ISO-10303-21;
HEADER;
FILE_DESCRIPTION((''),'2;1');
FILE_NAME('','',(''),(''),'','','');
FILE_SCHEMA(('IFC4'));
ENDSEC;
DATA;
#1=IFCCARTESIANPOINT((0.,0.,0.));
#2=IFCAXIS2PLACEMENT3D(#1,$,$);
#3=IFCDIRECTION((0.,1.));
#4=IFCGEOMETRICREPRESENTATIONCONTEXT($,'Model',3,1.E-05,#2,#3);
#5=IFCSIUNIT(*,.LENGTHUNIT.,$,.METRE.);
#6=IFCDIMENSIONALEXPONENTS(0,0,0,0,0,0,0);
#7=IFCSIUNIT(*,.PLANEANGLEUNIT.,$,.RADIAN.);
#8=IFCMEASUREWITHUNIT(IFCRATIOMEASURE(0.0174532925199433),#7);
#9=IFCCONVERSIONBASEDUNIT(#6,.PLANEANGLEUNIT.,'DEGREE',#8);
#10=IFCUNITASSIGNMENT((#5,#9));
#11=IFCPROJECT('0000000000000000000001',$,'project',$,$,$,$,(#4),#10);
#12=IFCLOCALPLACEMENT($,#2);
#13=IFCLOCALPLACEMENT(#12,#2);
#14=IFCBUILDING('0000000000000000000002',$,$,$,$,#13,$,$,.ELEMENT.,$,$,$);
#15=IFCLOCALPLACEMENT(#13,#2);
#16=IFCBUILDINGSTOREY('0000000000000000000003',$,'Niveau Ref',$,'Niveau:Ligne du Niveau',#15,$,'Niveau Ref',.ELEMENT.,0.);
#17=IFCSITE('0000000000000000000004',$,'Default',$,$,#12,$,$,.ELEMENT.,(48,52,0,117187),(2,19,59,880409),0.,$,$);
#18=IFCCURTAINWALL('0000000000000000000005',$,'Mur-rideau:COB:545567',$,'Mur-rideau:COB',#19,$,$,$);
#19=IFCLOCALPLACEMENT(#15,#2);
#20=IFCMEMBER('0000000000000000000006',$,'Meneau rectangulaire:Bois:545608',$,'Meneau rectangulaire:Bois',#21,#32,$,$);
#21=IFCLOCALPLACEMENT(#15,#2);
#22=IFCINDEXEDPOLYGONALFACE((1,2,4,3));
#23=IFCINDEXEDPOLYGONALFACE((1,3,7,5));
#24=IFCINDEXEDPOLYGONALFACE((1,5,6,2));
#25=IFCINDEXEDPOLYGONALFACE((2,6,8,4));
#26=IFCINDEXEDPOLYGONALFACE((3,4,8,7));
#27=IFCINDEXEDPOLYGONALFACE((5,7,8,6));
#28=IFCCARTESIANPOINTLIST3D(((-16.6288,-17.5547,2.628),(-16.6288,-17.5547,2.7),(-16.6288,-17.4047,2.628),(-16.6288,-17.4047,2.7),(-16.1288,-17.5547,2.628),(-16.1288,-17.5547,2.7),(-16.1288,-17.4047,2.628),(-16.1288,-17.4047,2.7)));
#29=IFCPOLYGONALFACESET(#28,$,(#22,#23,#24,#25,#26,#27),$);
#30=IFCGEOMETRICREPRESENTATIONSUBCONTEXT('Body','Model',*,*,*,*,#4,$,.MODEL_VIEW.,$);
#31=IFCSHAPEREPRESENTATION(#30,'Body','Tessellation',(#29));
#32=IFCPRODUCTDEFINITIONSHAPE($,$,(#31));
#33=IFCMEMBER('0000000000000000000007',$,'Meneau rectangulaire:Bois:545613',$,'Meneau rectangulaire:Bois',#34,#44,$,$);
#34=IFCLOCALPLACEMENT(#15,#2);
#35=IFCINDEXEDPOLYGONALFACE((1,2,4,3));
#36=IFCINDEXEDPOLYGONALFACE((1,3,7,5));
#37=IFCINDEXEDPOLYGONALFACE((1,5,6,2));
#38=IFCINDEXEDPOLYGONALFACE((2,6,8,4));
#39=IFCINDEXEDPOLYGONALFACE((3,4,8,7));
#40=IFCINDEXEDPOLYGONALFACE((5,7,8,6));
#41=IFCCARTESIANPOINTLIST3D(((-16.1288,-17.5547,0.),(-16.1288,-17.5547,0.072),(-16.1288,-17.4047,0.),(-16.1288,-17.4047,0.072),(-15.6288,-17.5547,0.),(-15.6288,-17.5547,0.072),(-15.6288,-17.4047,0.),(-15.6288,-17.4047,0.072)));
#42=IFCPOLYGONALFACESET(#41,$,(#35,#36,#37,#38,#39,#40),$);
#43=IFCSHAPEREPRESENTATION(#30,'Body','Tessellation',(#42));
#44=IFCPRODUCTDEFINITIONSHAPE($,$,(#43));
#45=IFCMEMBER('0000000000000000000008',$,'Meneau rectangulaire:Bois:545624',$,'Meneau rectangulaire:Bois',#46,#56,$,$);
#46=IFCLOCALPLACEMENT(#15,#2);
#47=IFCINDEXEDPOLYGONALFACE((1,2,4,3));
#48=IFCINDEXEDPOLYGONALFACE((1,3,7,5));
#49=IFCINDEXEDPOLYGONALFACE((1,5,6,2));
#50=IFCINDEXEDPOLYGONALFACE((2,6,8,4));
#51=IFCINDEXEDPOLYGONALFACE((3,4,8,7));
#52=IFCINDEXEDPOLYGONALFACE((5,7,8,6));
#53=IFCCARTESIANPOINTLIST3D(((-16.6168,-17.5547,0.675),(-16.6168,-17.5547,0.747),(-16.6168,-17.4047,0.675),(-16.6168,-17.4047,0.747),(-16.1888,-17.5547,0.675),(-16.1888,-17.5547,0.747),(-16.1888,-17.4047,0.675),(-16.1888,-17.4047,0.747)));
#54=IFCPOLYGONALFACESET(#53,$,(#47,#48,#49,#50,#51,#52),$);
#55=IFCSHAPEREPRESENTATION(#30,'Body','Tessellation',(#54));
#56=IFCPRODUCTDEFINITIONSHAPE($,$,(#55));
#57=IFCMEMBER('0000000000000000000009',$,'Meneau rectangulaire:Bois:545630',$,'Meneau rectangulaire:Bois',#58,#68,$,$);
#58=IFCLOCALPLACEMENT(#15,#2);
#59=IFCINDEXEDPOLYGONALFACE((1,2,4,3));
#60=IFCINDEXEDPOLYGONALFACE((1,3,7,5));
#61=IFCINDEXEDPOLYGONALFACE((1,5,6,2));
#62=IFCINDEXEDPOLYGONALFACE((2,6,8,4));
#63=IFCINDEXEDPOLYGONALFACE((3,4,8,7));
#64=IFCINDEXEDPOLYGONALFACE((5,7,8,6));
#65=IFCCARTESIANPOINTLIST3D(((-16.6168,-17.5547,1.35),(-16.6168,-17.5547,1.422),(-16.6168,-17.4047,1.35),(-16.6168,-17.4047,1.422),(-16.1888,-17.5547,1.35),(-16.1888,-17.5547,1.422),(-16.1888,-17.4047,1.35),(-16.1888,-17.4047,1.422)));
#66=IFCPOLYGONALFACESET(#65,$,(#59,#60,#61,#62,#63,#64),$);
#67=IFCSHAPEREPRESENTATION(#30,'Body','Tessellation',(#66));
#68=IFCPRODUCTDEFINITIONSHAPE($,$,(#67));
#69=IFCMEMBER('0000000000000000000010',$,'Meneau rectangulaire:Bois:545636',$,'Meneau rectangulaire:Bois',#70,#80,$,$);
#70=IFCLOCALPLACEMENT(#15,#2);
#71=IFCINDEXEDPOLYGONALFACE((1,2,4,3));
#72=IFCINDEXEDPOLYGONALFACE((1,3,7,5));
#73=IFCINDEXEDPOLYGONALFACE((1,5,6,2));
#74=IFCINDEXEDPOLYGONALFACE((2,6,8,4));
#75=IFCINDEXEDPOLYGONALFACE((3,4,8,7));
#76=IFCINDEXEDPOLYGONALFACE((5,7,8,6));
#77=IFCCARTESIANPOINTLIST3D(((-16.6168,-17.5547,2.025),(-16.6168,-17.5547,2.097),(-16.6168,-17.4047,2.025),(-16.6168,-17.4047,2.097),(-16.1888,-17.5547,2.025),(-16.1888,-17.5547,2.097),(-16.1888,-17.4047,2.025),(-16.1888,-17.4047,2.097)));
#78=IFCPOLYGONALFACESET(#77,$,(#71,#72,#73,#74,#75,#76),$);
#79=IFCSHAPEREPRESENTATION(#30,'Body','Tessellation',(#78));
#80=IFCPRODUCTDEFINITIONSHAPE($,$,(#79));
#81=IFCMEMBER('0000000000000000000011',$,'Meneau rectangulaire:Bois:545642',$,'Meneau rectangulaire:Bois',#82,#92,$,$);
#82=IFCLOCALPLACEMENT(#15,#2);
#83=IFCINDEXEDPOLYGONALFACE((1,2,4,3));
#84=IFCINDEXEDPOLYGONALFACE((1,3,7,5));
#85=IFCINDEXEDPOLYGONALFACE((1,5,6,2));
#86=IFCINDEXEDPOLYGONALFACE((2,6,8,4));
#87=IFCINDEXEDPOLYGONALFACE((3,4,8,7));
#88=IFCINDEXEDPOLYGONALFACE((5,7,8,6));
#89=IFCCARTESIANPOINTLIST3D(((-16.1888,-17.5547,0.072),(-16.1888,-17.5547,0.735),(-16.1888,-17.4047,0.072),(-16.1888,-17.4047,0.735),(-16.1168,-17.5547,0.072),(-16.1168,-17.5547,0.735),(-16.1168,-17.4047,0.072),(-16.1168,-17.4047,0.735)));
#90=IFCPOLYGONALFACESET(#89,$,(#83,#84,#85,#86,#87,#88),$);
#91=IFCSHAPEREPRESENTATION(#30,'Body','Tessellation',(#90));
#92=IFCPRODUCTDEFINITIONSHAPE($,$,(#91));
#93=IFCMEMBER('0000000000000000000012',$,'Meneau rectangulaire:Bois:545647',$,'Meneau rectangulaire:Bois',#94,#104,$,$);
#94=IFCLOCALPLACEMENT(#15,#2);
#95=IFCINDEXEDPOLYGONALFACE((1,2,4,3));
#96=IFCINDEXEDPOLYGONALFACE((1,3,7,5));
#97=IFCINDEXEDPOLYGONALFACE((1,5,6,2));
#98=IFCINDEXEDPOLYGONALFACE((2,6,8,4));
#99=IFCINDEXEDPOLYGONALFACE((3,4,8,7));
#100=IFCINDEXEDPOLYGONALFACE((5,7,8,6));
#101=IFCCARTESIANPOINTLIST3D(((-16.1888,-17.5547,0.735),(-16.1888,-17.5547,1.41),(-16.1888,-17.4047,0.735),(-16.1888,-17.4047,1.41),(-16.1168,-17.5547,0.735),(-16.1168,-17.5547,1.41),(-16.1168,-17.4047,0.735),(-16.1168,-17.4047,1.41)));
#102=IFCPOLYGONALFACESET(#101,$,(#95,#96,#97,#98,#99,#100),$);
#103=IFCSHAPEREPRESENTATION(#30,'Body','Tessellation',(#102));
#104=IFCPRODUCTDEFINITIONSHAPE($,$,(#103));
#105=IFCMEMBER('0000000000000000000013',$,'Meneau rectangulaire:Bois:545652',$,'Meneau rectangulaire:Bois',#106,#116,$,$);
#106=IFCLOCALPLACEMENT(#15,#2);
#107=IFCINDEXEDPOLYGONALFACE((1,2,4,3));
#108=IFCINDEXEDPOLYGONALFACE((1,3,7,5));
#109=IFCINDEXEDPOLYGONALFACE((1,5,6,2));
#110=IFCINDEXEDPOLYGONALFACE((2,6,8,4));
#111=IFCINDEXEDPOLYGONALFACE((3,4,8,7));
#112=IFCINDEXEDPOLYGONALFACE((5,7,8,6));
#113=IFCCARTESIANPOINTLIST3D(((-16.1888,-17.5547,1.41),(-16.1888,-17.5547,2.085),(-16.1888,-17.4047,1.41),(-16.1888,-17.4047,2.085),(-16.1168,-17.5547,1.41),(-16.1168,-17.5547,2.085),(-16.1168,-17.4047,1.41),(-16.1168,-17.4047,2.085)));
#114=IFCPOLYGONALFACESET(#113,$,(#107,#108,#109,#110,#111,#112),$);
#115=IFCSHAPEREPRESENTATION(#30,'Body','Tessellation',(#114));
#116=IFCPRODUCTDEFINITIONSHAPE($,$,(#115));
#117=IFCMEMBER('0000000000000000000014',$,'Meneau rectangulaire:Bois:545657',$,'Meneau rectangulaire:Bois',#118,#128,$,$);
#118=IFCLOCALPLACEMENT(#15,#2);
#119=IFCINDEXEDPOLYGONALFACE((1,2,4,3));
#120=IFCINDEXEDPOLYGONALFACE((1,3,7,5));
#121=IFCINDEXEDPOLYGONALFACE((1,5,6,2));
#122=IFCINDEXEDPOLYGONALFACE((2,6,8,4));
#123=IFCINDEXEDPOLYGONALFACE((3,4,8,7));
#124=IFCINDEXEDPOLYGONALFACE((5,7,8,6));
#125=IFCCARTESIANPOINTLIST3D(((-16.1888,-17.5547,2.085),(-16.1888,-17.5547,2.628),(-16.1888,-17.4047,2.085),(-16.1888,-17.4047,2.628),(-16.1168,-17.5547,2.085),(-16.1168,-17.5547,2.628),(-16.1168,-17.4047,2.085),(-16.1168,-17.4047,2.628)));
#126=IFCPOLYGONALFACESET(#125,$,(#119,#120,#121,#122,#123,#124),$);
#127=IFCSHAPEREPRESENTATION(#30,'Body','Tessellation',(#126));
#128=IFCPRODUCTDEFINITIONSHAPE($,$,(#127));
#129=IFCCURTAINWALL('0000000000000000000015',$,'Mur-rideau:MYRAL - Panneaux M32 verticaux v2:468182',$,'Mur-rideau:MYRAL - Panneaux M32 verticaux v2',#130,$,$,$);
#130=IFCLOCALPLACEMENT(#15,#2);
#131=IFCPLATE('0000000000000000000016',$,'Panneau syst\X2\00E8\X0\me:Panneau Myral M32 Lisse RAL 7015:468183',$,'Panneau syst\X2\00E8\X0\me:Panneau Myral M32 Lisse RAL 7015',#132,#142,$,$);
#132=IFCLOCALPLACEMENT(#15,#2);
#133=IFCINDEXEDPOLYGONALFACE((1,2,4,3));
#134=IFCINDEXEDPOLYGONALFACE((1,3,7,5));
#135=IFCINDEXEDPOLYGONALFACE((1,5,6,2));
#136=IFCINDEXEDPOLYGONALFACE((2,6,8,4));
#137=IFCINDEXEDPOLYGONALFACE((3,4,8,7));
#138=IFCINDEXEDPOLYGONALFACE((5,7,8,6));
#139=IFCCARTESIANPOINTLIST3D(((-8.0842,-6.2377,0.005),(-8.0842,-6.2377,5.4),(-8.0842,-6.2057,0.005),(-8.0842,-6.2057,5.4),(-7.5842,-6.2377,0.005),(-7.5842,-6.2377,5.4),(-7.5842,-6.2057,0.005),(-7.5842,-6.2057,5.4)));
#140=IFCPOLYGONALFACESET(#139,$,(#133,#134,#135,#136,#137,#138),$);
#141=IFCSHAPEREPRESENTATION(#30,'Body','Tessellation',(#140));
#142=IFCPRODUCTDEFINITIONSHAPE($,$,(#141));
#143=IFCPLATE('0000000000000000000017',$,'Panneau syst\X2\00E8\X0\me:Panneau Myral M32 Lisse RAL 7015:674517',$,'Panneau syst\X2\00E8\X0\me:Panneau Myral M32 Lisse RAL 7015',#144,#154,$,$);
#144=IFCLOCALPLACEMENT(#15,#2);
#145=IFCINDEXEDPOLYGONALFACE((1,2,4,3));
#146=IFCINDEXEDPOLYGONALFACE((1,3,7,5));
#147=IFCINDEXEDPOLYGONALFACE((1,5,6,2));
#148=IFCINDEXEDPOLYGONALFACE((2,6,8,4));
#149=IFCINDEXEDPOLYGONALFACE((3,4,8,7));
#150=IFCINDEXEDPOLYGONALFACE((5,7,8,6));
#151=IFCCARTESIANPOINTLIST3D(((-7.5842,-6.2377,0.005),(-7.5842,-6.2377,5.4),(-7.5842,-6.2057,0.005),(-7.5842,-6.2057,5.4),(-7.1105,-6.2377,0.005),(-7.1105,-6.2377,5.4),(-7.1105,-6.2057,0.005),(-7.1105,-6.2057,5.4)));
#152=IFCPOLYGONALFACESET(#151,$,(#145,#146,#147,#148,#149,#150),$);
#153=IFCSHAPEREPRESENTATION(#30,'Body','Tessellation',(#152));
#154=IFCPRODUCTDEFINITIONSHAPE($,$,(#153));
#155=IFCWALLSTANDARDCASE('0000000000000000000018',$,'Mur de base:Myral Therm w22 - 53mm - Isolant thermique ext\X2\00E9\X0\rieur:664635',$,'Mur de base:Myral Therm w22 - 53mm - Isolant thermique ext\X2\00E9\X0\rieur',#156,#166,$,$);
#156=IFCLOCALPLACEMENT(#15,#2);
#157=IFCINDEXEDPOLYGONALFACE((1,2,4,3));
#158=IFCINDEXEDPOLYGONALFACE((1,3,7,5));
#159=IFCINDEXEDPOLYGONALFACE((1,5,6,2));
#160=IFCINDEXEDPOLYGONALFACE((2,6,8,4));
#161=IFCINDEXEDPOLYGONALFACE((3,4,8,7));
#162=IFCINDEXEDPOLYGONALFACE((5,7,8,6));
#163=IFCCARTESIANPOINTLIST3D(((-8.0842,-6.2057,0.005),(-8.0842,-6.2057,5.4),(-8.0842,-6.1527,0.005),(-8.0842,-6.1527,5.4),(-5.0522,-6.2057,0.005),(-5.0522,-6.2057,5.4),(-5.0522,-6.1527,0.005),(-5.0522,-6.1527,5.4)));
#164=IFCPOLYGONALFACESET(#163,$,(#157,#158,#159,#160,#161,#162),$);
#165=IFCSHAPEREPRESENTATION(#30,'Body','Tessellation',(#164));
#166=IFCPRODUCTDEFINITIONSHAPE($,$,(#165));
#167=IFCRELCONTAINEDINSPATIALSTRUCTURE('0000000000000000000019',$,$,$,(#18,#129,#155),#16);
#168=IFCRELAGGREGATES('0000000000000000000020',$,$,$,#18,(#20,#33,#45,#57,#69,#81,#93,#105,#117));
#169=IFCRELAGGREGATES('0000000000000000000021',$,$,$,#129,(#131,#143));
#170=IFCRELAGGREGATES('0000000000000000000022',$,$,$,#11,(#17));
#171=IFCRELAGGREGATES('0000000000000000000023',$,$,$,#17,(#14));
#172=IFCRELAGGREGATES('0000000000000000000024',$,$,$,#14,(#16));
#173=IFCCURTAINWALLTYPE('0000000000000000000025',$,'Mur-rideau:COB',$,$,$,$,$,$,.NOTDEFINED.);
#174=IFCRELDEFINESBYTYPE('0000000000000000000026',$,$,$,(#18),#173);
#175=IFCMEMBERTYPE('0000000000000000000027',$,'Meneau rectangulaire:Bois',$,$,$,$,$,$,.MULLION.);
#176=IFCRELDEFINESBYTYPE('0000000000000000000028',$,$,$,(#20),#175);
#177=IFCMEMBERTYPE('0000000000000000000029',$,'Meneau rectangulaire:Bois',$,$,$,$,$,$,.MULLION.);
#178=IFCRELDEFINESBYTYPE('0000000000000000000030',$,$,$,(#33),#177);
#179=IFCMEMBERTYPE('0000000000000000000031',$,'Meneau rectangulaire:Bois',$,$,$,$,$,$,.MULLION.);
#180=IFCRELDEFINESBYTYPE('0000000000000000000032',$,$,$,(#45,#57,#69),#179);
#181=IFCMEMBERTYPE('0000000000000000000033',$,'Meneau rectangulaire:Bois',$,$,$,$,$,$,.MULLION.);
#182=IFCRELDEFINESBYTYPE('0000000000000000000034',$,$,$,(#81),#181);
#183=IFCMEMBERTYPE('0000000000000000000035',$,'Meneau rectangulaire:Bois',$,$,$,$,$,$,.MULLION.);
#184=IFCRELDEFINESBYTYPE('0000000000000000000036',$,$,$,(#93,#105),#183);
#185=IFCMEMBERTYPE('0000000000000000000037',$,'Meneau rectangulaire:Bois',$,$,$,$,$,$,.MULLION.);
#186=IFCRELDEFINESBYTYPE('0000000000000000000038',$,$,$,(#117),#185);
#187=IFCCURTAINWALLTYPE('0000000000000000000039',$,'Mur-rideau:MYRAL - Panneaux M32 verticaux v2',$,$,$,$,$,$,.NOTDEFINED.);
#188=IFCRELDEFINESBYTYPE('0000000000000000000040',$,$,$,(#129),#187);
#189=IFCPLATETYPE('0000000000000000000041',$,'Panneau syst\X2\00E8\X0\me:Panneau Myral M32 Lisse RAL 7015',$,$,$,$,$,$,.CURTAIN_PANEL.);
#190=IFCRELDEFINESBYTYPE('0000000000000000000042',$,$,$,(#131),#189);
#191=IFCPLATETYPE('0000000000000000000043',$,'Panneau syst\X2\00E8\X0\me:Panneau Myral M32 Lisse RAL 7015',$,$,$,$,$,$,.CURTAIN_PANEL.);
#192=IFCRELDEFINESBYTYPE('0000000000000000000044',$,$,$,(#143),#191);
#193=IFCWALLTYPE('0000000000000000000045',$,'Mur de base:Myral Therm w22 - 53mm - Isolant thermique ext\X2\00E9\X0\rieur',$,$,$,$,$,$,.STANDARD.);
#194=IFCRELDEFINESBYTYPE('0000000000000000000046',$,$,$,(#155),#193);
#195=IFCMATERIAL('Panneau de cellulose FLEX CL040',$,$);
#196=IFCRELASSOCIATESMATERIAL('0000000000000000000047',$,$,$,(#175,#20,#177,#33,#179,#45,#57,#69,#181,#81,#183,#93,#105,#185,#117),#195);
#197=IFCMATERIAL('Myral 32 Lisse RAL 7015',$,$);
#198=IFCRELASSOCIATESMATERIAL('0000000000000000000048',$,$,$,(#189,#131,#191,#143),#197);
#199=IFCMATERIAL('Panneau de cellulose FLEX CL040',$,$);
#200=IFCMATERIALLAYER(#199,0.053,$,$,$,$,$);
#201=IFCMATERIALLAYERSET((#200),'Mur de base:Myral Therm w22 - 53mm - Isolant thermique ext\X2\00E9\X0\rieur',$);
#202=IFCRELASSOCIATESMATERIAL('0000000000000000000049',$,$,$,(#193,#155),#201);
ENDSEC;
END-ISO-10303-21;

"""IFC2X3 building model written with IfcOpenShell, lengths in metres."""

from ifc_helpers import new_model, entity, si_unit, converted_unit, direction, frame, frame_2d, origin, origin_2d_with_axis, place, context, subcontext, project, spatial, rectangle, extrude, source, transform, mapped, material, layer, layer_set, layer_usage, type_object, type_shapes, element, aggregate, save


model = new_model("IFC2X3")

# Units and contexts
model_context = context("Model", 3, precision=1e-05, world=origin(), true_north=direction((0.0, 1.0)))
body_context = subcontext(model_context, "Body", "Model", "MODEL_VIEW")
ifc_project = project(units=[si_unit("LENGTHUNIT", "METRE"), converted_unit("PLANEANGLEUNIT", "DEGREE", entity("IfcRatioMeasure", 0.0174532925199433), si_unit("PLANEANGLEUNIT", "RADIAN"), dimensions=[0, 0, 0, 0, 0, 0, 0])], contexts=[model_context])

# Site, building, storey
site_placement = place(None, origin())
site = spatial("IfcSite", under=ifc_project, at=site_placement, Name="Default", CompositionType="ELEMENT", RefLatitude=(48, 52, 0, 117187), RefLongitude=(2, 19, 59, 880409), RefElevation=0.0)
building_placement = place(site_placement, origin())
building = spatial("IfcBuilding", under=site, at=building_placement, CompositionType="ELEMENT")
storey_placement = place(building_placement, origin())
storey = spatial("IfcBuildingStorey", under=building, at=storey_placement, Name="Niveau Ref", ObjectType="Niveau:Ligne du Niveau", LongName="Niveau Ref", CompositionType="ELEMENT", Elevation=0.0)

# Curtain wall, members
curtain_wall_type_1 = type_object("IfcCurtainWallType", Name="Mur-rideau:COB", PredefinedType="NOTDEFINED")
curtain_wall_1_placement = place(storey_placement, origin())
curtain_wall_1 = element("IfcCurtainWall", 1, at=curtain_wall_1_placement, inside=storey, type_object=curtain_wall_type_1, Name="Mur-rideau:COB:545567", ObjectType="Mur-rideau:COB")
ifc_material_1 = material(Name="Panneau de cellulose FLEX CL040")
member_type_1 = type_object("IfcMemberType", Name="Meneau rectangulaire:Bois", PredefinedType="MULLION", material=ifc_material_1)
shared_shape_1 = source(origin(), body_context, "Body", "SweptSolid", [
    extrude(rectangle(XDim=0.15, YDim=0.072, at=origin_2d_with_axis()), frame((-0.036, 0.0, -0.5), z_axis=(0.0, 0.0, 1.0), x_axis=(0.0, -1.0, 0.0)), (0.0, 0.0, 1.0), 0.5),
])
type_shapes(member_type_1, [shared_shape_1])
member_1_placement = place(storey_placement, frame((-16.1288, -17.4797, 2.7), z_axis=(1.0, 0.0, 0.0), x_axis=(0.0, 0.0, 1.0)))
member_1 = element("IfcMember", 2, at=member_1_placement, type_object=member_type_1, material=ifc_material_1, Name="Meneau rectangulaire:Bois:545608", ObjectType="Meneau rectangulaire:Bois", context=body_context, shape_type="MappedRepresentation", body=[
    mapped(shared_shape_1, transform((0.0, 0.0, 0.0), scale=1.0)),
])
member_type_2 = type_object("IfcMemberType", Name="Meneau rectangulaire:Bois", PredefinedType="MULLION", material=ifc_material_1)
shared_shape_2 = source(origin(), body_context, "Body", "SweptSolid", [
    extrude(rectangle(XDim=0.15, YDim=0.072, at=origin_2d_with_axis()), frame((-0.036, 0.0, -0.5), z_axis=(0.0, 0.0, 1.0), x_axis=(0.0, -1.0, 0.0)), (0.0, 0.0, 1.0), 0.5),
])
type_shapes(member_type_2, [shared_shape_2])
member_2_placement = place(storey_placement, frame((-16.1288, -17.4797, 0.0), z_axis=(-1.0, 0.0, 0.0), x_axis=(0.0, 0.0, -1.0)))
member_2 = element("IfcMember", 3, at=member_2_placement, type_object=member_type_2, material=ifc_material_1, Name="Meneau rectangulaire:Bois:545613", ObjectType="Meneau rectangulaire:Bois", context=body_context, shape_type="MappedRepresentation", body=[
    mapped(shared_shape_2, transform((0.0, 0.0, 0.0), scale=1.0)),
])
member_type_3 = type_object("IfcMemberType", Name="Meneau rectangulaire:Bois", PredefinedType="MULLION", material=ifc_material_1)
shared_shape_3 = source(origin(), body_context, "Body", "SweptSolid", [
    extrude(rectangle(XDim=0.15, YDim=0.072, at=origin_2d_with_axis()), frame((-0.024, 0.0, -0.428), z_axis=(0.0, 0.0, 1.0), x_axis=(0.0, -1.0, 0.0)), (0.0, 0.0, 1.0), 0.428),
])
type_shapes(member_type_3, [shared_shape_3])
member_3_placement = place(storey_placement, frame((-16.1888, -17.4797, 0.735), z_axis=(1.0, 0.0, 0.0), x_axis=(0.0, 0.0, 1.0)))
member_3 = element("IfcMember", 4, at=member_3_placement, type_object=member_type_3, material=ifc_material_1, Name="Meneau rectangulaire:Bois:545624", ObjectType="Meneau rectangulaire:Bois", context=body_context, shape_type="MappedRepresentation", body=[
    mapped(shared_shape_3, transform((0.0, 0.0, 0.0), scale=1.0)),
])
member_4_placement = place(storey_placement, frame((-16.1888, -17.4797, 1.41), z_axis=(1.0, 0.0, 0.0), x_axis=(0.0, 0.0, 1.0)))
member_4 = element("IfcMember", 5, at=member_4_placement, type_object=member_type_3, material=ifc_material_1, Name="Meneau rectangulaire:Bois:545630", ObjectType="Meneau rectangulaire:Bois", context=body_context, shape_type="MappedRepresentation", body=[
    mapped(shared_shape_3, transform((0.0, 0.0, 0.0), scale=1.0)),
])
member_5_placement = place(storey_placement, frame((-16.1888, -17.4797, 2.085), z_axis=(1.0, 0.0, 0.0), x_axis=(0.0, 0.0, 1.0)))
member_5 = element("IfcMember", 6, at=member_5_placement, type_object=member_type_3, material=ifc_material_1, Name="Meneau rectangulaire:Bois:545636", ObjectType="Meneau rectangulaire:Bois", context=body_context, shape_type="MappedRepresentation", body=[
    mapped(shared_shape_3, transform((0.0, 0.0, 0.0), scale=1.0)),
])
member_type_4 = type_object("IfcMemberType", Name="Meneau rectangulaire:Bois", PredefinedType="MULLION", material=ifc_material_1)
shared_shape_4 = source(origin(), body_context, "Body", "SweptSolid", [
    extrude(rectangle(XDim=0.15, YDim=0.072, at=origin_2d_with_axis()), frame((-0.024, 0.0, -0.663), z_axis=(0.0, 0.0, 1.0), x_axis=(0.0, -1.0, 0.0)), (0.0, 0.0, 1.0), 0.663),
])
type_shapes(member_type_4, [shared_shape_4])
member_6_placement = place(storey_placement, frame((-16.1288, -17.4797, 0.072), z_axis=(0.0, 0.0, -1.0), x_axis=(1.0, 0.0, 0.0)))
member_6 = element("IfcMember", 7, at=member_6_placement, type_object=member_type_4, material=ifc_material_1, Name="Meneau rectangulaire:Bois:545642", ObjectType="Meneau rectangulaire:Bois", context=body_context, shape_type="MappedRepresentation", body=[
    mapped(shared_shape_4, transform((0.0, 0.0, 0.0), scale=1.0)),
])
member_type_5 = type_object("IfcMemberType", Name="Meneau rectangulaire:Bois", PredefinedType="MULLION", material=ifc_material_1)
shared_shape_5 = source(origin(), body_context, "Body", "SweptSolid", [
    extrude(rectangle(XDim=0.15, YDim=0.072, at=origin_2d_with_axis()), frame((-0.024, 0.0, -0.675), z_axis=(0.0, 0.0, 1.0), x_axis=(0.0, -1.0, 0.0)), (0.0, 0.0, 1.0), 0.675),
])
type_shapes(member_type_5, [shared_shape_5])
member_7_placement = place(storey_placement, frame((-16.1288, -17.4797, 0.735), z_axis=(0.0, 0.0, -1.0), x_axis=(1.0, 0.0, 0.0)))
member_7 = element("IfcMember", 8, at=member_7_placement, type_object=member_type_5, material=ifc_material_1, Name="Meneau rectangulaire:Bois:545647", ObjectType="Meneau rectangulaire:Bois", context=body_context, shape_type="MappedRepresentation", body=[
    mapped(shared_shape_5, transform((0.0, 0.0, 0.0), scale=1.0)),
])
member_8_placement = place(storey_placement, frame((-16.1288, -17.4797, 1.41), z_axis=(0.0, 0.0, -1.0), x_axis=(1.0, 0.0, 0.0)))
member_8 = element("IfcMember", 9, at=member_8_placement, type_object=member_type_5, material=ifc_material_1, Name="Meneau rectangulaire:Bois:545652", ObjectType="Meneau rectangulaire:Bois", context=body_context, shape_type="MappedRepresentation", body=[
    mapped(shared_shape_5, transform((0.0, 0.0, 0.0), scale=1.0)),
])
member_type_6 = type_object("IfcMemberType", Name="Meneau rectangulaire:Bois", PredefinedType="MULLION", material=ifc_material_1)
shared_shape_6 = source(origin(), body_context, "Body", "SweptSolid", [
    extrude(rectangle(XDim=0.15, YDim=0.072, at=origin_2d_with_axis()), frame((-0.024, 0.0, -0.543), z_axis=(0.0, 0.0, 1.0), x_axis=(0.0, -1.0, 0.0)), (0.0, 0.0, 1.0), 0.543),
])
type_shapes(member_type_6, [shared_shape_6])
member_9_placement = place(storey_placement, frame((-16.1288, -17.4797, 2.085), z_axis=(0.0, 0.0, -1.0), x_axis=(1.0, 0.0, 0.0)))
member_9 = element("IfcMember", 10, at=member_9_placement, type_object=member_type_6, material=ifc_material_1, Name="Meneau rectangulaire:Bois:545657", ObjectType="Meneau rectangulaire:Bois", context=body_context, shape_type="MappedRepresentation", body=[
    mapped(shared_shape_6, transform((0.0, 0.0, 0.0), scale=1.0)),
])
aggregate(curtain_wall_1, [member_1, member_2, member_3, member_4, member_5, member_6, member_7, member_8, member_9])

# Curtain wall, plates
curtain_wall_type_2 = type_object("IfcCurtainWallType", Name="Mur-rideau:MYRAL - Panneaux M32 verticaux v2", PredefinedType="NOTDEFINED")
curtain_wall_2_placement = place(storey_placement, origin())
curtain_wall_2 = element("IfcCurtainWall", 11, at=curtain_wall_2_placement, inside=storey, type_object=curtain_wall_type_2, Name="Mur-rideau:MYRAL - Panneaux M32 verticaux v2:468182", ObjectType="Mur-rideau:MYRAL - Panneaux M32 verticaux v2")
ifc_material_2 = material(Name="Myral 32 Lisse RAL 7015")
plate_type_1 = type_object("IfcPlateType", Name="Panneau système:Panneau Myral M32 Lisse RAL 7015", PredefinedType="CURTAIN_PANEL", material=ifc_material_2)
shared_shape_7 = source(origin(), body_context, "Body", "SweptSolid", [
    extrude(rectangle(XDim=0.032, YDim=0.5, at=origin_2d_with_axis()), frame((0.0, -0.016, 0.0), z_axis=(0.0, 0.0, 1.0), x_axis=(0.0, 1.0, 0.0)), (0.0, 0.0, 1.0), 5.395),
])
type_shapes(plate_type_1, [shared_shape_7])
plate_1_placement = place(curtain_wall_2_placement, frame((-7.8342, -6.2057, 0.005)))
plate_1 = element("IfcPlate", 12, at=plate_1_placement, type_object=plate_type_1, material=ifc_material_2, Name="Panneau système:Panneau Myral M32 Lisse RAL 7015:468183", ObjectType="Panneau système:Panneau Myral M32 Lisse RAL 7015", context=body_context, shape_type="MappedRepresentation", body=[
    mapped(shared_shape_7, transform((0.0, 0.0, 0.0), scale=1.0)),
])
plate_type_2 = type_object("IfcPlateType", Name="Panneau système:Panneau Myral M32 Lisse RAL 7015", PredefinedType="CURTAIN_PANEL", material=ifc_material_2)
shared_shape_8 = source(origin(), body_context, "Body", "SweptSolid", [
    extrude(rectangle(XDim=0.032, YDim=0.4737, at=origin_2d_with_axis()), frame((0.0, -0.016, 0.0), z_axis=(0.0, 0.0, 1.0), x_axis=(0.0, 1.0, 0.0)), (0.0, 0.0, 1.0), 5.395),
])
type_shapes(plate_type_2, [shared_shape_8])
plate_2_placement = place(curtain_wall_2_placement, frame((-7.3474, -6.2057, 0.005)))
plate_2 = element("IfcPlate", 13, at=plate_2_placement, type_object=plate_type_2, material=ifc_material_2, Name="Panneau système:Panneau Myral M32 Lisse RAL 7015:674517", ObjectType="Panneau système:Panneau Myral M32 Lisse RAL 7015", context=body_context, shape_type="MappedRepresentation", body=[
    mapped(shared_shape_8, transform((0.0, 0.0, 0.0), scale=1.0)),
])
aggregate(curtain_wall_2, [plate_1, plate_2])

# Wall
ifc_material_3 = material(Name="Panneau de cellulose FLEX CL040")
ifc_layer = layer(ifc_material_3, 0.053)
ifc_layer_set = layer_set([ifc_layer], Name="Mur de base:Myral Therm w22 - 53mm - Isolant thermique extérieur")
ifc_layer_usage = layer_usage(ifc_layer_set, "AXIS2", "NEGATIVE", 0.0265)
wall_type = type_object("IfcWallType", Name="Mur de base:Myral Therm w22 - 53mm - Isolant thermique extérieur", PredefinedType="STANDARD", material=ifc_layer_set)
wall_placement = place(storey_placement, frame((-8.0842, -6.1792, 0.005)))
element("IfcWallStandardCase", 14, at=wall_placement, inside=storey, type_object=wall_type, material=ifc_layer_usage, Name="Mur de base:Myral Therm w22 - 53mm - Isolant thermique extérieur:664635", ObjectType="Mur de base:Myral Therm w22 - 53mm - Isolant thermique extérieur", context=body_context, shape_type="SweptSolid", body=[
    extrude(rectangle(XDim=3.032, YDim=0.053, at=frame_2d((1.516, 0.0), x_axis=(-1.0, 0.0))), origin(), (0.0, 0.0, 1.0), 5.395),
])

save(model, "model.ifc")
